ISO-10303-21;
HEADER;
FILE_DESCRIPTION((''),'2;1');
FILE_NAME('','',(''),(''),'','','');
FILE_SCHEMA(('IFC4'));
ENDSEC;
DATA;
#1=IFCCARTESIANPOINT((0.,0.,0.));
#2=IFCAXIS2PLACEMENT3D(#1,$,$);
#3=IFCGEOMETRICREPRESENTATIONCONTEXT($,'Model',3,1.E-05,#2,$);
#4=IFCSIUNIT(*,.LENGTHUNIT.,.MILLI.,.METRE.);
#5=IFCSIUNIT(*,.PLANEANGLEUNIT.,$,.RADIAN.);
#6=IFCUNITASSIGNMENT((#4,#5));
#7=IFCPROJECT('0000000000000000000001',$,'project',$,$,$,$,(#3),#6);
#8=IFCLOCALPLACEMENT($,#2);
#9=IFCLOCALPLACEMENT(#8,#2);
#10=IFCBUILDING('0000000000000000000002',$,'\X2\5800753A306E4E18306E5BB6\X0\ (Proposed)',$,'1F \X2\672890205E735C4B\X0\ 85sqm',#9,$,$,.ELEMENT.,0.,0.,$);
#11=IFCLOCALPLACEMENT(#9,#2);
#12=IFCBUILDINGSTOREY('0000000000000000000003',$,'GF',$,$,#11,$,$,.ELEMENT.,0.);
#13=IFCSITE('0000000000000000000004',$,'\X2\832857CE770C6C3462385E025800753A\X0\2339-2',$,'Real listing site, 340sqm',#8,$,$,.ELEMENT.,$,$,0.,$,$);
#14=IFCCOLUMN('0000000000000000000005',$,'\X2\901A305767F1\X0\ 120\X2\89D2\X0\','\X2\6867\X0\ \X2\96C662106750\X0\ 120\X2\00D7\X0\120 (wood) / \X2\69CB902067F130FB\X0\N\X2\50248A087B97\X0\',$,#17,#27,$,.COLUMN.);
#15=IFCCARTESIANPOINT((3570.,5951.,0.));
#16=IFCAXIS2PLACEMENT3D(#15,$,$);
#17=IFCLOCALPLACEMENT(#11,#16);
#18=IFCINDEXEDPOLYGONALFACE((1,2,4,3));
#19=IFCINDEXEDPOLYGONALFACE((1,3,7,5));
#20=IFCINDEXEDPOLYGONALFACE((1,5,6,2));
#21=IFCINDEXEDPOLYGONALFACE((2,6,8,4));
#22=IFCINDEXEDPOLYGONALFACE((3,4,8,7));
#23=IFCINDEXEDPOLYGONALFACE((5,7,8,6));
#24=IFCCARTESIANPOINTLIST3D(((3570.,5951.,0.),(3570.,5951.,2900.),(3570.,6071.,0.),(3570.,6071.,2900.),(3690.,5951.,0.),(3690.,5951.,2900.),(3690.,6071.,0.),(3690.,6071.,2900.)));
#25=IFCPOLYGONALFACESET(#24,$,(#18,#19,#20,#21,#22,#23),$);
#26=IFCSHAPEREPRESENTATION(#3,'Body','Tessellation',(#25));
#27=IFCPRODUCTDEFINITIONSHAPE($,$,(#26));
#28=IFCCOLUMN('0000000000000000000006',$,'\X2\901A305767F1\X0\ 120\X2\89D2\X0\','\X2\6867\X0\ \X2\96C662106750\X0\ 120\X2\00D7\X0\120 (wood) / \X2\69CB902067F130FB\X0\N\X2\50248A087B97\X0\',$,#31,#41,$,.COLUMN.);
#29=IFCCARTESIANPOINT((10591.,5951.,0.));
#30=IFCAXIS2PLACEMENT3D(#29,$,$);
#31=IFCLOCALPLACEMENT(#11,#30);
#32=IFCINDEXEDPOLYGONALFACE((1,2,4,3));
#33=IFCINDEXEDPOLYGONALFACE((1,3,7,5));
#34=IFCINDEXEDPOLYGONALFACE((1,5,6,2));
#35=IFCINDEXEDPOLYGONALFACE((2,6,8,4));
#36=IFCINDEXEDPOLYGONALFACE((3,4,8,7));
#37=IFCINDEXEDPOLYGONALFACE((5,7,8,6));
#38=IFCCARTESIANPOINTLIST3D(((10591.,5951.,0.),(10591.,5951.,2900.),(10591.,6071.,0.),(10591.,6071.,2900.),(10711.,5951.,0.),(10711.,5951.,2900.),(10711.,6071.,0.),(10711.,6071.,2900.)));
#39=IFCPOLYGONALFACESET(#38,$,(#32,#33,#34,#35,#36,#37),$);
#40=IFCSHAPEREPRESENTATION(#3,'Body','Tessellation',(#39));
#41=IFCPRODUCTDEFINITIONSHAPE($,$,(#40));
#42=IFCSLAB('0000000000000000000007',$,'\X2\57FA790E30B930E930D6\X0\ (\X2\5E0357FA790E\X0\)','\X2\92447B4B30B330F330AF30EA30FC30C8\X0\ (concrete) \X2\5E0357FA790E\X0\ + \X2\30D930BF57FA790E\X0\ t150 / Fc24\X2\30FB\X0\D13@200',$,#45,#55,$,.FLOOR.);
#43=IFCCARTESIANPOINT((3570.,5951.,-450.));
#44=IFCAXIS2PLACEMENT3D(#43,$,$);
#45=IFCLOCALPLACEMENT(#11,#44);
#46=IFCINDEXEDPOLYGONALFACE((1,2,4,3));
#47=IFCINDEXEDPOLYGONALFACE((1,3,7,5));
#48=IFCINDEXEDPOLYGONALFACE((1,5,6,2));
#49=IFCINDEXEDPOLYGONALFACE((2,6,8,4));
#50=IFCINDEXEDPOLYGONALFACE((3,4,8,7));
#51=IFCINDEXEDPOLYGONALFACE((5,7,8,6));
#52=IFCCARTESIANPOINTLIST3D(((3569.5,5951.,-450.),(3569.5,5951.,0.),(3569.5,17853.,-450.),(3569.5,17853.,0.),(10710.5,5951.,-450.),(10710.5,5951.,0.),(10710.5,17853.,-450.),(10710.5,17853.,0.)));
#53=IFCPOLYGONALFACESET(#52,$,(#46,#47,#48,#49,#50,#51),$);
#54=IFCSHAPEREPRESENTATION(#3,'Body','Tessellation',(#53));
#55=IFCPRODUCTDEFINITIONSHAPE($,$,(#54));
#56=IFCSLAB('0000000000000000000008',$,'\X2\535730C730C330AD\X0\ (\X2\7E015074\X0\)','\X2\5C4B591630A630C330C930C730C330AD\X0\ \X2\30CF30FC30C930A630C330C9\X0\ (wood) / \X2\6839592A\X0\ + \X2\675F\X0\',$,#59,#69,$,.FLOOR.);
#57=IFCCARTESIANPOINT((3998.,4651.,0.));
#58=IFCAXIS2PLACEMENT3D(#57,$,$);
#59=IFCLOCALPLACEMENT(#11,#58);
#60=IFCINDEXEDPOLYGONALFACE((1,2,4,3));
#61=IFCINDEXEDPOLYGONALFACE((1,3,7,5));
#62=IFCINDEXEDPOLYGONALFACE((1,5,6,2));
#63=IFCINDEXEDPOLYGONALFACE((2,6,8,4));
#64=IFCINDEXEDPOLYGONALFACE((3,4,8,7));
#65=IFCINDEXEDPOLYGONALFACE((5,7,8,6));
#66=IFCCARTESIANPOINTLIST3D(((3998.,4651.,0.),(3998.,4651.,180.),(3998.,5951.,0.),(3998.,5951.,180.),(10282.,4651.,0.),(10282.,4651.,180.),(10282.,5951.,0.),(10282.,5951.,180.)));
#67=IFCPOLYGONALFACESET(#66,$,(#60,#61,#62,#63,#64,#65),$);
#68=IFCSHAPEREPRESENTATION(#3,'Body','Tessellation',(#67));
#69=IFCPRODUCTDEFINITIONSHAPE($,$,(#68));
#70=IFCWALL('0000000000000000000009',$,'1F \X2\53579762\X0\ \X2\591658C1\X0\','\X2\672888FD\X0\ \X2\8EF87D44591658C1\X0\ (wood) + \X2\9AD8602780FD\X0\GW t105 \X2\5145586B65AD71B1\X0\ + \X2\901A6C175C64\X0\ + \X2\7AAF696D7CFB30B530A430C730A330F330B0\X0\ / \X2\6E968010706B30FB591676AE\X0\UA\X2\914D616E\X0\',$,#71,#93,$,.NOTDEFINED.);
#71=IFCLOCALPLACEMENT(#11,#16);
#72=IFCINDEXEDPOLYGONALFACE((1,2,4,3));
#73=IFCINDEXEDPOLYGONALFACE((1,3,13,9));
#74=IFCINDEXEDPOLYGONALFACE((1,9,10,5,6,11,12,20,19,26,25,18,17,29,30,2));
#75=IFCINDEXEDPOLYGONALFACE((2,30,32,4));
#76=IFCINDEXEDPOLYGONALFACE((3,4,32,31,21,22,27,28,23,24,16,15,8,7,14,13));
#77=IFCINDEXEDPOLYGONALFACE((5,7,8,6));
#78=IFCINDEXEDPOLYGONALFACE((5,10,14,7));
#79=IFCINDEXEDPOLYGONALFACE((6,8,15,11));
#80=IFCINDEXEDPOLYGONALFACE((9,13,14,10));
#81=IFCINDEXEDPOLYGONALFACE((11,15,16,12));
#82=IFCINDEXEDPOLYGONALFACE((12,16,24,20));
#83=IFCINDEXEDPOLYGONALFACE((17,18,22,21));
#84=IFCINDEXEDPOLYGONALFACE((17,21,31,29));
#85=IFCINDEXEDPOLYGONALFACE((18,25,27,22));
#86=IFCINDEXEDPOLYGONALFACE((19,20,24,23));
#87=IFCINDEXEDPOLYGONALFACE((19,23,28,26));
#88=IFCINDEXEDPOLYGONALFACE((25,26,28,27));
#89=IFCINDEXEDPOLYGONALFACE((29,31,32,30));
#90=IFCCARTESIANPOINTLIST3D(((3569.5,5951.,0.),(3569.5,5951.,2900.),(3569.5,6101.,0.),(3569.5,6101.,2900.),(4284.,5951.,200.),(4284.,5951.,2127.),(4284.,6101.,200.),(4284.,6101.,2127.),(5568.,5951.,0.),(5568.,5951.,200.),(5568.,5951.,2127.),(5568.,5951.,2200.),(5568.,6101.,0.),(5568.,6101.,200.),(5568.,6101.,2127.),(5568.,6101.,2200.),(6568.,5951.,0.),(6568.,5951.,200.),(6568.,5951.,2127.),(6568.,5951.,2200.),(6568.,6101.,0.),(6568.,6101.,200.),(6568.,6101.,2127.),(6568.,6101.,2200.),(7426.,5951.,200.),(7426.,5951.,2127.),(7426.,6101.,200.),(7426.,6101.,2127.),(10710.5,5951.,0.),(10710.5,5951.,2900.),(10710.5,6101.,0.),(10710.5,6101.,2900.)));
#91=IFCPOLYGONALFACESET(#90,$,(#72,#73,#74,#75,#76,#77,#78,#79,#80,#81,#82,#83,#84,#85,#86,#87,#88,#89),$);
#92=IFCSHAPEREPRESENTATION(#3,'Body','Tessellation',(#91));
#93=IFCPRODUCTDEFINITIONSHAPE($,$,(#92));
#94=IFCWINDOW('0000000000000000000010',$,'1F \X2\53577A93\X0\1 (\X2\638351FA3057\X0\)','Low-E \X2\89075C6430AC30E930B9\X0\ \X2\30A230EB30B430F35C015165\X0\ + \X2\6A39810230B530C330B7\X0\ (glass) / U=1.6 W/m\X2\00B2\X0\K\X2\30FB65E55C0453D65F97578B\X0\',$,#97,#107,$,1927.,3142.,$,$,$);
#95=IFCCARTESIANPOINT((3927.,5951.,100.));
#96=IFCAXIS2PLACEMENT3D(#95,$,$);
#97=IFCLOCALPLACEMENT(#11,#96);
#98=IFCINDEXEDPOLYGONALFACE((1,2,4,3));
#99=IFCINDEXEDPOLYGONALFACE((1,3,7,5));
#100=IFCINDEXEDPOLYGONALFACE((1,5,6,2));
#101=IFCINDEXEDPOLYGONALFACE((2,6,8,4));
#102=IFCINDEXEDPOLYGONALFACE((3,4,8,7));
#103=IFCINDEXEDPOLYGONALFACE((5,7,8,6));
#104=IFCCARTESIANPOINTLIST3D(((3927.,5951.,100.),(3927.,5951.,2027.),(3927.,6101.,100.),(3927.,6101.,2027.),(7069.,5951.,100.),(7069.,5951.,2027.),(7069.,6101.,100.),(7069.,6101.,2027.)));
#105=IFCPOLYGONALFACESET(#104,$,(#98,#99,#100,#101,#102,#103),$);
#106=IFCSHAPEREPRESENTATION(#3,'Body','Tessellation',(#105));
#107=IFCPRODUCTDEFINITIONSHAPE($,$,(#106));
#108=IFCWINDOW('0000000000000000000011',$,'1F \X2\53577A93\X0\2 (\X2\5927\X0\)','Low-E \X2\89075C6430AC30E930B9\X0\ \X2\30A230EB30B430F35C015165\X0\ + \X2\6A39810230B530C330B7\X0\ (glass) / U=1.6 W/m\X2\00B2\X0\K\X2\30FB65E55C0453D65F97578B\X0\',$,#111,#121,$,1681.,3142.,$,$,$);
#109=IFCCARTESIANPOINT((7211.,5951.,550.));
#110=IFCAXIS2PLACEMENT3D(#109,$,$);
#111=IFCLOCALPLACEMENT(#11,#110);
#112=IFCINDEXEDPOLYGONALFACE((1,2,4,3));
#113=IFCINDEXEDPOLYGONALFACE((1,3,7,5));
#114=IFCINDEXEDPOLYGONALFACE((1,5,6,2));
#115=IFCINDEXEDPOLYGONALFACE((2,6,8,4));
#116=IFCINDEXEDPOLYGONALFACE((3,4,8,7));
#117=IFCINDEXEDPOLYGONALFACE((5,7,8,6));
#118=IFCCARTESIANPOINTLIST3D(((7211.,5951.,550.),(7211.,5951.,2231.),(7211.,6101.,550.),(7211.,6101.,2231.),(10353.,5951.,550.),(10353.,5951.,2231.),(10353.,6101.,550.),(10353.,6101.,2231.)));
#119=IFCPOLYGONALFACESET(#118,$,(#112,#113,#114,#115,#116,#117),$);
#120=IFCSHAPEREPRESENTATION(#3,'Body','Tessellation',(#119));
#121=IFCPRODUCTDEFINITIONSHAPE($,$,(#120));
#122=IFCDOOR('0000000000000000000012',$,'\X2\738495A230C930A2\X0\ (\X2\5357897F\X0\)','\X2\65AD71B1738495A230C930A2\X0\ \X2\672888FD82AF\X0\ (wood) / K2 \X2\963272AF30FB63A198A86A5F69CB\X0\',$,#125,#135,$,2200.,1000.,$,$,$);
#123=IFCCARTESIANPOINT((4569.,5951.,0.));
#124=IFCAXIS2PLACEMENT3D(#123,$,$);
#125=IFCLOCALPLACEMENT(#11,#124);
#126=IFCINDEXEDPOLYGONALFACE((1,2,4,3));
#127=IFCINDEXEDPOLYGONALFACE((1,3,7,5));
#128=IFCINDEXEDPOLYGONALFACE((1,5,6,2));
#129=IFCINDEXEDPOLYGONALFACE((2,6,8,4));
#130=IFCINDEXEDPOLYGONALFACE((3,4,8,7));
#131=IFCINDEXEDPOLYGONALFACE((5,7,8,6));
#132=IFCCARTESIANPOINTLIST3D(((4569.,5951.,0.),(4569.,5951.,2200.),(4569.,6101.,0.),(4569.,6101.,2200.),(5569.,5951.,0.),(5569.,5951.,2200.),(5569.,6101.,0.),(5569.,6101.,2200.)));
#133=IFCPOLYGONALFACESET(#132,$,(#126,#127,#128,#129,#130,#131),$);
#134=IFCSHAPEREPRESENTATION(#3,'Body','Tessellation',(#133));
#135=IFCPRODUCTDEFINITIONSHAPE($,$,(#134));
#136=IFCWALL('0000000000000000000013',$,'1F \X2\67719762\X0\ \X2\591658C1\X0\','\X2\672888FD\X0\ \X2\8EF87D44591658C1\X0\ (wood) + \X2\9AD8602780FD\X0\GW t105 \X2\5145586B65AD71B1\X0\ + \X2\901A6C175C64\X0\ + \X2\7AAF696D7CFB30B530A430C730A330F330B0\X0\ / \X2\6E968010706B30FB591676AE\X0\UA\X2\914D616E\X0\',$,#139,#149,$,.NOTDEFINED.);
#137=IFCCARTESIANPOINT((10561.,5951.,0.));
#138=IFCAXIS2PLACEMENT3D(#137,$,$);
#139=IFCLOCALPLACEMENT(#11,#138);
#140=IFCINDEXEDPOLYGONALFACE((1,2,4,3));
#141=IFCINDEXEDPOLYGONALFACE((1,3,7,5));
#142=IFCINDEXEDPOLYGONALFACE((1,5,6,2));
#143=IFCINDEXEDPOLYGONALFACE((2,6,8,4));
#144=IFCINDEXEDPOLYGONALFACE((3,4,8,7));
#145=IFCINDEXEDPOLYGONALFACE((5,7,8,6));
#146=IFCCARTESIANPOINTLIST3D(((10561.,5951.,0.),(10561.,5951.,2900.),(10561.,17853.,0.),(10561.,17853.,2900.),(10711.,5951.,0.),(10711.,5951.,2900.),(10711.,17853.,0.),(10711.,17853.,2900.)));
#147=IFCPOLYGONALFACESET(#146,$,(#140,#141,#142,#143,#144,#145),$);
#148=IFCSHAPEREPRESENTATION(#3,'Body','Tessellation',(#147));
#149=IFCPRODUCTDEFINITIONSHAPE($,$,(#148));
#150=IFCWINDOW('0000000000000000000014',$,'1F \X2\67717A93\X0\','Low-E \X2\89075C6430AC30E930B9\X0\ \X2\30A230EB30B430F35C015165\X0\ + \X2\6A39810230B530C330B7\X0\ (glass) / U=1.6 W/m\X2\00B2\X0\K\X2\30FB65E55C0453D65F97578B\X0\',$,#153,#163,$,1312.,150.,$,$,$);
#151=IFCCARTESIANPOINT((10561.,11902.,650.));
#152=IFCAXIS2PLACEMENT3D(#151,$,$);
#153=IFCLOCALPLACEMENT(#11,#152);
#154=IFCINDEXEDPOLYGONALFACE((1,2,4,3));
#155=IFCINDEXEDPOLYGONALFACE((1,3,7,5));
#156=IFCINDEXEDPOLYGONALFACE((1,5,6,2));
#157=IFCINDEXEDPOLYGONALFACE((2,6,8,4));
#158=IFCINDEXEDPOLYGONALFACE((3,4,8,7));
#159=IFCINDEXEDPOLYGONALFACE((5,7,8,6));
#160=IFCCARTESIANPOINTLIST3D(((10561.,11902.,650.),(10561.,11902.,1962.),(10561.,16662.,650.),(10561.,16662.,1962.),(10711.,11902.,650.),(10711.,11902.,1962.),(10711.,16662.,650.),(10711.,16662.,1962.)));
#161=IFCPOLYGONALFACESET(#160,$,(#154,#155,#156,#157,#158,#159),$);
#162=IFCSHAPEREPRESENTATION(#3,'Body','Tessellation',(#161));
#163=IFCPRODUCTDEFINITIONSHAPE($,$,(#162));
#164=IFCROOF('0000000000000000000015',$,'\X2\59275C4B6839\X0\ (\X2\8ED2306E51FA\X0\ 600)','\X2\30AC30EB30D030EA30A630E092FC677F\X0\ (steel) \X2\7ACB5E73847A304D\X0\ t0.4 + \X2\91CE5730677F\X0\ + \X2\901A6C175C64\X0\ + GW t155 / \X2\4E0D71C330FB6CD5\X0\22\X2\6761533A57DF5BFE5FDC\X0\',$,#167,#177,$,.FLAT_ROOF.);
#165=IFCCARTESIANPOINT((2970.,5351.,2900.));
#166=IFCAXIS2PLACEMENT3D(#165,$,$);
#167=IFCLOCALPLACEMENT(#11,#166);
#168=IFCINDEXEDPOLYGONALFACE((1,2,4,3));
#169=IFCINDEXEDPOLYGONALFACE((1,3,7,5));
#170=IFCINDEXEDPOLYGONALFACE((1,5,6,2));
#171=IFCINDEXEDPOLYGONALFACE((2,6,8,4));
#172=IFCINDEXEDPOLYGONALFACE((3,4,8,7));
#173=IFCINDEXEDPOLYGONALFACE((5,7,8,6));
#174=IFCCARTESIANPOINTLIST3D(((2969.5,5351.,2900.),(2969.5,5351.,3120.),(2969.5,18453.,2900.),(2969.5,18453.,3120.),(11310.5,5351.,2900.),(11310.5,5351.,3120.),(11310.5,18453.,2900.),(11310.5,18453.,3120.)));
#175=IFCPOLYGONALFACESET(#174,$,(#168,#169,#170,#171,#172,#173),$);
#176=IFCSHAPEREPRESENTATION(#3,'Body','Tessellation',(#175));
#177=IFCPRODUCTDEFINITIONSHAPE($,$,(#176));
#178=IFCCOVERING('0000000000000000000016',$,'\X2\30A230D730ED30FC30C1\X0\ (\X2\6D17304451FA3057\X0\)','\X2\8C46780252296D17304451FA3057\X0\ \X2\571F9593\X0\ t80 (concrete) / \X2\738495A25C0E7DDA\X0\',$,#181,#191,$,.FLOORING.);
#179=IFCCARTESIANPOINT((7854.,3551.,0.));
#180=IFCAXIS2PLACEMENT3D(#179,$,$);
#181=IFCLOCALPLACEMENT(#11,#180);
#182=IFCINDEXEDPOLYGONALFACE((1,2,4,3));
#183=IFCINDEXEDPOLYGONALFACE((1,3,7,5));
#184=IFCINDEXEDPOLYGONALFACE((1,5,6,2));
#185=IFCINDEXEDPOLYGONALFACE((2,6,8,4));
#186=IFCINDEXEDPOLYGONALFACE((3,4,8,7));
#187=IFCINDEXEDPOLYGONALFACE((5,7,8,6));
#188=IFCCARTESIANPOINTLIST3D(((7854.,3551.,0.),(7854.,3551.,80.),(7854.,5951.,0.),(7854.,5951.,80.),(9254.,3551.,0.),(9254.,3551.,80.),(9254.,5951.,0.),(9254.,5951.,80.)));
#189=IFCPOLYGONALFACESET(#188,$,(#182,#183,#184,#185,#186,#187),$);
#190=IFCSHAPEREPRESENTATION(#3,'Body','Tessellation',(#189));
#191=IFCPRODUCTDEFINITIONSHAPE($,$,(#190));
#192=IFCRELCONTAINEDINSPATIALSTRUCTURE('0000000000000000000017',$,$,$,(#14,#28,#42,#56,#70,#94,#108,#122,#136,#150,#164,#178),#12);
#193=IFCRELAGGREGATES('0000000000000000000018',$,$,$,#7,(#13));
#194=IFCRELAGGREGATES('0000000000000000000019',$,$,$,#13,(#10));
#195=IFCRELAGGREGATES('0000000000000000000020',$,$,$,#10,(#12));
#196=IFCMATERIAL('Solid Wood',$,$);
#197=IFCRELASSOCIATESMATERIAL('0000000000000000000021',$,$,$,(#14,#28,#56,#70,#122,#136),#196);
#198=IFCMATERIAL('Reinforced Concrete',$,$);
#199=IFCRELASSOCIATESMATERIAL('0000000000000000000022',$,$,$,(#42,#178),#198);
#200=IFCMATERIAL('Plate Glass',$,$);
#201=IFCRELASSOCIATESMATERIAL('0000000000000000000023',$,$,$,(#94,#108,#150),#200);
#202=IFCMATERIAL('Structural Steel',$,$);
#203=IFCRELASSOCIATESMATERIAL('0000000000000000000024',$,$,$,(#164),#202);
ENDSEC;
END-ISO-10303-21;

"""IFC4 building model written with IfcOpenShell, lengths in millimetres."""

from ifc_helpers import new_model, si_unit, frame, frame_2d, origin, place, context, project, spatial, rectangle, extrude, material, element, fill, save


model = new_model("IFC4")

# Units and contexts
model_context = context("Model", 3, precision=1e-05, world=origin())
ifc_project = project(units=[si_unit("LENGTHUNIT", "METRE", prefix="MILLI"), si_unit("PLANEANGLEUNIT", "RADIAN")], contexts=[model_context])

# Site, building, storey
site_placement = place(None, origin())
site = spatial("IfcSite", under=ifc_project, at=site_placement, Name="茨城県水戸市堀町2339-2", ObjectType="Real listing site, 340sqm", CompositionType="ELEMENT", RefElevation=0.0)
building_placement = place(site_placement, origin())
building = spatial("IfcBuilding", under=site, at=building_placement, Name="堀町の丘の家 (Proposed)", ObjectType="1F 木造平屋 85sqm", CompositionType="ELEMENT", ElevationOfRefHeight=0.0, ElevationOfTerrain=0.0)
storey_placement = place(building_placement, origin())
storey = spatial("IfcBuildingStorey", under=building, at=storey_placement, Name="GF", CompositionType="ELEMENT", Elevation=0.0)

# Columns
ifc_material_1 = material(Name="Solid Wood")
column_1_placement = place(storey_placement, frame((3570.0, 5951.0, 0.0)))
element("IfcColumn", 1, at=column_1_placement, inside=storey, material=ifc_material_1, Name="通し柱 120角", Description="桧 集成材 120×120 (wood) / 構造柱・N値計算", PredefinedType="COLUMN", context=model_context, shape_type="SweptSolid", body=[
    extrude(rectangle(XDim=120.0, YDim=120.0, at=frame_2d((60.0, 60.0))), frame((3570.0, 5951.0, 0.0)), (0.0, 0.0, 1.0), 2900.0),
])
column_2_placement = place(storey_placement, frame((10591.0, 5951.0, 0.0)))
element("IfcColumn", 2, at=column_2_placement, inside=storey, material=ifc_material_1, Name="通し柱 120角", Description="桧 集成材 120×120 (wood) / 構造柱・N値計算", PredefinedType="COLUMN", context=model_context, shape_type="SweptSolid", body=[
    extrude(rectangle(XDim=120.0, YDim=120.0, at=frame_2d((60.0, 60.0))), frame((10591.0, 5951.0, 0.0)), (0.0, 0.0, 1.0), 2900.0),
])

# Slabs
ifc_material_2 = material(Name="Reinforced Concrete")
slab_1_placement = place(storey_placement, frame((3570.0, 5951.0, -450.0)))
element("IfcSlab", 3, at=slab_1_placement, inside=storey, material=ifc_material_2, Name="基礎スラブ (布基礎)", Description="鉄筋コンクリート (concrete) 布基礎 + ベタ基礎 t150 / Fc24・D13@200", PredefinedType="FLOOR", context=model_context, shape_type="SweptSolid", body=[
    extrude(rectangle(XDim=7141.0, YDim=11902.0, at=frame_2d((3570.0, 5951.0))), frame((3570.0, 5951.0, -450.0)), (0.0, 0.0, 1.0), 450.0),
])
slab_2_placement = place(storey_placement, frame((3998.0, 4651.0, 0.0)))
element("IfcSlab", 4, at=slab_2_placement, inside=storey, material=ifc_material_1, Name="南デッキ (縁側)", Description="屋外ウッドデッキ ハードウッド (wood) / 根太 + 束", PredefinedType="FLOOR", context=model_context, shape_type="SweptSolid", body=[
    extrude(rectangle(XDim=6284.0, YDim=1300.0, at=frame_2d((3142.0, 650.0))), frame((3998.0, 4651.0, 0.0)), (0.0, 0.0, 1.0), 180.0),
])

# Wall, openings, windows, door
wall_1_placement = place(storey_placement, frame((3570.0, 5951.0, 0.0)))
wall_1 = element("IfcWall", 5, at=wall_1_placement, inside=storey, material=ifc_material_1, Name="1F 南面 外壁", Description="木製 軸組外壁 (wood) + 高性能GW t105 充填断熱 + 通気層 + 窯業系サイディング / 準耐火・外皮UA配慮", PredefinedType="NOTDEFINED", context=model_context, shape_type="SweptSolid", body=[
    extrude(rectangle(XDim=7141.0, YDim=150.0, at=frame_2d((3570.0, 75.0))), frame((3570.0, 5951.0, 0.0)), (0.0, 0.0, 1.0), 2900.0),
])
opening_1_placement = place(storey_placement, frame((3927.0, 5951.0, 100.0)))
opening_1 = element("IfcOpeningElement", 6, at=opening_1_placement, cuts=wall_1, PredefinedType="NOTDEFINED", context=model_context, shape_type="SweptSolid", body=[
    extrude(rectangle(XDim=3142.0, YDim=150.0, at=frame_2d((1571.0, 75.0))), frame((3927.0, 5951.0, 100.0)), (0.0, 0.0, 1.0), 1927.0),
])
opening_2_placement = place(storey_placement, frame((7211.0, 5951.0, 550.0)))
opening_2 = element("IfcOpeningElement", 7, at=opening_2_placement, cuts=wall_1, PredefinedType="NOTDEFINED", context=model_context, shape_type="SweptSolid", body=[
    extrude(rectangle(XDim=3142.0, YDim=150.0, at=frame_2d((1571.0, 75.0))), frame((7211.0, 5951.0, 550.0)), (0.0, 0.0, 1.0), 1681.0),
])
opening_3_placement = place(storey_placement, frame((4569.0, 5951.0, 0.0)))
opening_3 = element("IfcOpeningElement", 8, at=opening_3_placement, cuts=wall_1, PredefinedType="NOTDEFINED", context=model_context, shape_type="SweptSolid", body=[
    extrude(rectangle(XDim=1000.0, YDim=150.0, at=frame_2d((500.0, 75.0))), frame((4569.0, 5951.0, 0.0)), (0.0, 0.0, 1.0), 2200.0),
])
ifc_material_3 = material(Name="Plate Glass")
window_1_placement = place(storey_placement, frame((3927.0, 5951.0, 100.0)))
window_1 = element("IfcWindow", 9, at=window_1_placement, inside=storey, material=ifc_material_3, Name="1F 南窓1 (掃出し)", Description="Low-E 複層ガラス アルゴン封入 + 樹脂サッシ (glass) / U=1.6 W/m²K・日射取得型", OverallHeight=1927.0, OverallWidth=3142.0, context=model_context, shape_type="SweptSolid", body=[
    extrude(rectangle(XDim=3142.0, YDim=150.0, at=frame_2d((1571.0, 75.0))), frame((3927.0, 5951.0, 100.0)), (0.0, 0.0, 1.0), 1927.0),
])
fill(opening_1, window_1)
window_2_placement = place(storey_placement, frame((7211.0, 5951.0, 550.0)))
window_2 = element("IfcWindow", 10, at=window_2_placement, inside=storey, material=ifc_material_3, Name="1F 南窓2 (大)", Description="Low-E 複層ガラス アルゴン封入 + 樹脂サッシ (glass) / U=1.6 W/m²K・日射取得型", OverallHeight=1681.0, OverallWidth=3142.0, context=model_context, shape_type="SweptSolid", body=[
    extrude(rectangle(XDim=3142.0, YDim=150.0, at=frame_2d((1571.0, 75.0))), frame((7211.0, 5951.0, 550.0)), (0.0, 0.0, 1.0), 1681.0),
])
fill(opening_2, window_2)
door_placement = place(storey_placement, frame((4569.0, 5951.0, 0.0)))
door = element("IfcDoor", 11, at=door_placement, inside=storey, material=ifc_material_1, Name="玄関ドア (南西)", Description="断熱玄関ドア 木製芯 (wood) / K2 防犯・採風機構", OverallHeight=2200.0, OverallWidth=1000.0, context=model_context, shape_type="SweptSolid", body=[
    extrude(rectangle(XDim=1000.0, YDim=150.0, at=frame_2d((500.0, 75.0))), frame((4569.0, 5951.0, 0.0)), (0.0, 0.0, 1.0), 2200.0),
])
fill(opening_3, door)

# Wall, opening, window
wall_2_placement = place(storey_placement, frame((10561.0, 5951.0, 0.0)))
wall_2 = element("IfcWall", 12, at=wall_2_placement, inside=storey, material=ifc_material_1, Name="1F 東面 外壁", Description="木製 軸組外壁 (wood) + 高性能GW t105 充填断熱 + 通気層 + 窯業系サイディング / 準耐火・外皮UA配慮", PredefinedType="NOTDEFINED", context=model_context, shape_type="SweptSolid", body=[
    extrude(rectangle(XDim=150.0, YDim=11902.0, at=frame_2d((75.0, 5951.0))), frame((10561.0, 5951.0, 0.0)), (0.0, 0.0, 1.0), 2900.0),
])
opening_4_placement = place(storey_placement, frame((10561.0, 11902.0, 650.0)))
opening_4 = element("IfcOpeningElement", 13, at=opening_4_placement, cuts=wall_2, PredefinedType="NOTDEFINED", context=model_context, shape_type="SweptSolid", body=[
    extrude(rectangle(XDim=150.0, YDim=4760.0, at=frame_2d((75.0, 2380.0))), frame((10561.0, 11902.0, 650.0)), (0.0, 0.0, 1.0), 1312.0),
])
window_3_placement = place(storey_placement, frame((10561.0, 11902.0, 650.0)))
window_3 = element("IfcWindow", 14, at=window_3_placement, inside=storey, material=ifc_material_3, Name="1F 東窓", Description="Low-E 複層ガラス アルゴン封入 + 樹脂サッシ (glass) / U=1.6 W/m²K・日射取得型", OverallHeight=1312.0, OverallWidth=150.0, context=model_context, shape_type="SweptSolid", body=[
    extrude(rectangle(XDim=150.0, YDim=4760.0, at=frame_2d((75.0, 2380.0))), frame((10561.0, 11902.0, 650.0)), (0.0, 0.0, 1.0), 1312.0),
])
fill(opening_4, window_3)

# Roof
ifc_material_4 = material(Name="Structural Steel")
roof_placement = place(storey_placement, frame((2970.0, 5351.0, 2900.0)))
element("IfcRoof", 15, at=roof_placement, inside=storey, material=ifc_material_4, Name="大屋根 (軒の出 600)", Description="ガルバリウム鋼板 (steel) 立平葺き t0.4 + 野地板 + 通気層 + GW t155 / 不燃・法22条区域対応", PredefinedType="FLAT_ROOF", context=model_context, shape_type="SweptSolid", body=[
    extrude(rectangle(XDim=8341.0, YDim=13102.0, at=frame_2d((4170.0, 6551.0))), frame((2970.0, 5351.0, 2900.0)), (0.0, 0.0, 1.0), 220.0),
])

# Covering
covering_1_placement = place(storey_placement, frame((7854.0, 3551.0, 0.0)))
element("IfcCovering", 16, at=covering_1_placement, inside=storey, material=ifc_material_2, Name="アプローチ (洗い出し)", Description="豆砂利洗い出し 土間 t80 (concrete) / 玄関導線", PredefinedType="FLOORING", context=model_context, shape_type="SweptSolid", body=[
    extrude(rectangle(XDim=1400.0, YDim=2400.0, at=frame_2d((700.0, 1200.0))), frame((7854.0, 3551.0, 0.0)), (0.0, 0.0, 1.0), 80.0),
])

save(model, "model.ifc")
